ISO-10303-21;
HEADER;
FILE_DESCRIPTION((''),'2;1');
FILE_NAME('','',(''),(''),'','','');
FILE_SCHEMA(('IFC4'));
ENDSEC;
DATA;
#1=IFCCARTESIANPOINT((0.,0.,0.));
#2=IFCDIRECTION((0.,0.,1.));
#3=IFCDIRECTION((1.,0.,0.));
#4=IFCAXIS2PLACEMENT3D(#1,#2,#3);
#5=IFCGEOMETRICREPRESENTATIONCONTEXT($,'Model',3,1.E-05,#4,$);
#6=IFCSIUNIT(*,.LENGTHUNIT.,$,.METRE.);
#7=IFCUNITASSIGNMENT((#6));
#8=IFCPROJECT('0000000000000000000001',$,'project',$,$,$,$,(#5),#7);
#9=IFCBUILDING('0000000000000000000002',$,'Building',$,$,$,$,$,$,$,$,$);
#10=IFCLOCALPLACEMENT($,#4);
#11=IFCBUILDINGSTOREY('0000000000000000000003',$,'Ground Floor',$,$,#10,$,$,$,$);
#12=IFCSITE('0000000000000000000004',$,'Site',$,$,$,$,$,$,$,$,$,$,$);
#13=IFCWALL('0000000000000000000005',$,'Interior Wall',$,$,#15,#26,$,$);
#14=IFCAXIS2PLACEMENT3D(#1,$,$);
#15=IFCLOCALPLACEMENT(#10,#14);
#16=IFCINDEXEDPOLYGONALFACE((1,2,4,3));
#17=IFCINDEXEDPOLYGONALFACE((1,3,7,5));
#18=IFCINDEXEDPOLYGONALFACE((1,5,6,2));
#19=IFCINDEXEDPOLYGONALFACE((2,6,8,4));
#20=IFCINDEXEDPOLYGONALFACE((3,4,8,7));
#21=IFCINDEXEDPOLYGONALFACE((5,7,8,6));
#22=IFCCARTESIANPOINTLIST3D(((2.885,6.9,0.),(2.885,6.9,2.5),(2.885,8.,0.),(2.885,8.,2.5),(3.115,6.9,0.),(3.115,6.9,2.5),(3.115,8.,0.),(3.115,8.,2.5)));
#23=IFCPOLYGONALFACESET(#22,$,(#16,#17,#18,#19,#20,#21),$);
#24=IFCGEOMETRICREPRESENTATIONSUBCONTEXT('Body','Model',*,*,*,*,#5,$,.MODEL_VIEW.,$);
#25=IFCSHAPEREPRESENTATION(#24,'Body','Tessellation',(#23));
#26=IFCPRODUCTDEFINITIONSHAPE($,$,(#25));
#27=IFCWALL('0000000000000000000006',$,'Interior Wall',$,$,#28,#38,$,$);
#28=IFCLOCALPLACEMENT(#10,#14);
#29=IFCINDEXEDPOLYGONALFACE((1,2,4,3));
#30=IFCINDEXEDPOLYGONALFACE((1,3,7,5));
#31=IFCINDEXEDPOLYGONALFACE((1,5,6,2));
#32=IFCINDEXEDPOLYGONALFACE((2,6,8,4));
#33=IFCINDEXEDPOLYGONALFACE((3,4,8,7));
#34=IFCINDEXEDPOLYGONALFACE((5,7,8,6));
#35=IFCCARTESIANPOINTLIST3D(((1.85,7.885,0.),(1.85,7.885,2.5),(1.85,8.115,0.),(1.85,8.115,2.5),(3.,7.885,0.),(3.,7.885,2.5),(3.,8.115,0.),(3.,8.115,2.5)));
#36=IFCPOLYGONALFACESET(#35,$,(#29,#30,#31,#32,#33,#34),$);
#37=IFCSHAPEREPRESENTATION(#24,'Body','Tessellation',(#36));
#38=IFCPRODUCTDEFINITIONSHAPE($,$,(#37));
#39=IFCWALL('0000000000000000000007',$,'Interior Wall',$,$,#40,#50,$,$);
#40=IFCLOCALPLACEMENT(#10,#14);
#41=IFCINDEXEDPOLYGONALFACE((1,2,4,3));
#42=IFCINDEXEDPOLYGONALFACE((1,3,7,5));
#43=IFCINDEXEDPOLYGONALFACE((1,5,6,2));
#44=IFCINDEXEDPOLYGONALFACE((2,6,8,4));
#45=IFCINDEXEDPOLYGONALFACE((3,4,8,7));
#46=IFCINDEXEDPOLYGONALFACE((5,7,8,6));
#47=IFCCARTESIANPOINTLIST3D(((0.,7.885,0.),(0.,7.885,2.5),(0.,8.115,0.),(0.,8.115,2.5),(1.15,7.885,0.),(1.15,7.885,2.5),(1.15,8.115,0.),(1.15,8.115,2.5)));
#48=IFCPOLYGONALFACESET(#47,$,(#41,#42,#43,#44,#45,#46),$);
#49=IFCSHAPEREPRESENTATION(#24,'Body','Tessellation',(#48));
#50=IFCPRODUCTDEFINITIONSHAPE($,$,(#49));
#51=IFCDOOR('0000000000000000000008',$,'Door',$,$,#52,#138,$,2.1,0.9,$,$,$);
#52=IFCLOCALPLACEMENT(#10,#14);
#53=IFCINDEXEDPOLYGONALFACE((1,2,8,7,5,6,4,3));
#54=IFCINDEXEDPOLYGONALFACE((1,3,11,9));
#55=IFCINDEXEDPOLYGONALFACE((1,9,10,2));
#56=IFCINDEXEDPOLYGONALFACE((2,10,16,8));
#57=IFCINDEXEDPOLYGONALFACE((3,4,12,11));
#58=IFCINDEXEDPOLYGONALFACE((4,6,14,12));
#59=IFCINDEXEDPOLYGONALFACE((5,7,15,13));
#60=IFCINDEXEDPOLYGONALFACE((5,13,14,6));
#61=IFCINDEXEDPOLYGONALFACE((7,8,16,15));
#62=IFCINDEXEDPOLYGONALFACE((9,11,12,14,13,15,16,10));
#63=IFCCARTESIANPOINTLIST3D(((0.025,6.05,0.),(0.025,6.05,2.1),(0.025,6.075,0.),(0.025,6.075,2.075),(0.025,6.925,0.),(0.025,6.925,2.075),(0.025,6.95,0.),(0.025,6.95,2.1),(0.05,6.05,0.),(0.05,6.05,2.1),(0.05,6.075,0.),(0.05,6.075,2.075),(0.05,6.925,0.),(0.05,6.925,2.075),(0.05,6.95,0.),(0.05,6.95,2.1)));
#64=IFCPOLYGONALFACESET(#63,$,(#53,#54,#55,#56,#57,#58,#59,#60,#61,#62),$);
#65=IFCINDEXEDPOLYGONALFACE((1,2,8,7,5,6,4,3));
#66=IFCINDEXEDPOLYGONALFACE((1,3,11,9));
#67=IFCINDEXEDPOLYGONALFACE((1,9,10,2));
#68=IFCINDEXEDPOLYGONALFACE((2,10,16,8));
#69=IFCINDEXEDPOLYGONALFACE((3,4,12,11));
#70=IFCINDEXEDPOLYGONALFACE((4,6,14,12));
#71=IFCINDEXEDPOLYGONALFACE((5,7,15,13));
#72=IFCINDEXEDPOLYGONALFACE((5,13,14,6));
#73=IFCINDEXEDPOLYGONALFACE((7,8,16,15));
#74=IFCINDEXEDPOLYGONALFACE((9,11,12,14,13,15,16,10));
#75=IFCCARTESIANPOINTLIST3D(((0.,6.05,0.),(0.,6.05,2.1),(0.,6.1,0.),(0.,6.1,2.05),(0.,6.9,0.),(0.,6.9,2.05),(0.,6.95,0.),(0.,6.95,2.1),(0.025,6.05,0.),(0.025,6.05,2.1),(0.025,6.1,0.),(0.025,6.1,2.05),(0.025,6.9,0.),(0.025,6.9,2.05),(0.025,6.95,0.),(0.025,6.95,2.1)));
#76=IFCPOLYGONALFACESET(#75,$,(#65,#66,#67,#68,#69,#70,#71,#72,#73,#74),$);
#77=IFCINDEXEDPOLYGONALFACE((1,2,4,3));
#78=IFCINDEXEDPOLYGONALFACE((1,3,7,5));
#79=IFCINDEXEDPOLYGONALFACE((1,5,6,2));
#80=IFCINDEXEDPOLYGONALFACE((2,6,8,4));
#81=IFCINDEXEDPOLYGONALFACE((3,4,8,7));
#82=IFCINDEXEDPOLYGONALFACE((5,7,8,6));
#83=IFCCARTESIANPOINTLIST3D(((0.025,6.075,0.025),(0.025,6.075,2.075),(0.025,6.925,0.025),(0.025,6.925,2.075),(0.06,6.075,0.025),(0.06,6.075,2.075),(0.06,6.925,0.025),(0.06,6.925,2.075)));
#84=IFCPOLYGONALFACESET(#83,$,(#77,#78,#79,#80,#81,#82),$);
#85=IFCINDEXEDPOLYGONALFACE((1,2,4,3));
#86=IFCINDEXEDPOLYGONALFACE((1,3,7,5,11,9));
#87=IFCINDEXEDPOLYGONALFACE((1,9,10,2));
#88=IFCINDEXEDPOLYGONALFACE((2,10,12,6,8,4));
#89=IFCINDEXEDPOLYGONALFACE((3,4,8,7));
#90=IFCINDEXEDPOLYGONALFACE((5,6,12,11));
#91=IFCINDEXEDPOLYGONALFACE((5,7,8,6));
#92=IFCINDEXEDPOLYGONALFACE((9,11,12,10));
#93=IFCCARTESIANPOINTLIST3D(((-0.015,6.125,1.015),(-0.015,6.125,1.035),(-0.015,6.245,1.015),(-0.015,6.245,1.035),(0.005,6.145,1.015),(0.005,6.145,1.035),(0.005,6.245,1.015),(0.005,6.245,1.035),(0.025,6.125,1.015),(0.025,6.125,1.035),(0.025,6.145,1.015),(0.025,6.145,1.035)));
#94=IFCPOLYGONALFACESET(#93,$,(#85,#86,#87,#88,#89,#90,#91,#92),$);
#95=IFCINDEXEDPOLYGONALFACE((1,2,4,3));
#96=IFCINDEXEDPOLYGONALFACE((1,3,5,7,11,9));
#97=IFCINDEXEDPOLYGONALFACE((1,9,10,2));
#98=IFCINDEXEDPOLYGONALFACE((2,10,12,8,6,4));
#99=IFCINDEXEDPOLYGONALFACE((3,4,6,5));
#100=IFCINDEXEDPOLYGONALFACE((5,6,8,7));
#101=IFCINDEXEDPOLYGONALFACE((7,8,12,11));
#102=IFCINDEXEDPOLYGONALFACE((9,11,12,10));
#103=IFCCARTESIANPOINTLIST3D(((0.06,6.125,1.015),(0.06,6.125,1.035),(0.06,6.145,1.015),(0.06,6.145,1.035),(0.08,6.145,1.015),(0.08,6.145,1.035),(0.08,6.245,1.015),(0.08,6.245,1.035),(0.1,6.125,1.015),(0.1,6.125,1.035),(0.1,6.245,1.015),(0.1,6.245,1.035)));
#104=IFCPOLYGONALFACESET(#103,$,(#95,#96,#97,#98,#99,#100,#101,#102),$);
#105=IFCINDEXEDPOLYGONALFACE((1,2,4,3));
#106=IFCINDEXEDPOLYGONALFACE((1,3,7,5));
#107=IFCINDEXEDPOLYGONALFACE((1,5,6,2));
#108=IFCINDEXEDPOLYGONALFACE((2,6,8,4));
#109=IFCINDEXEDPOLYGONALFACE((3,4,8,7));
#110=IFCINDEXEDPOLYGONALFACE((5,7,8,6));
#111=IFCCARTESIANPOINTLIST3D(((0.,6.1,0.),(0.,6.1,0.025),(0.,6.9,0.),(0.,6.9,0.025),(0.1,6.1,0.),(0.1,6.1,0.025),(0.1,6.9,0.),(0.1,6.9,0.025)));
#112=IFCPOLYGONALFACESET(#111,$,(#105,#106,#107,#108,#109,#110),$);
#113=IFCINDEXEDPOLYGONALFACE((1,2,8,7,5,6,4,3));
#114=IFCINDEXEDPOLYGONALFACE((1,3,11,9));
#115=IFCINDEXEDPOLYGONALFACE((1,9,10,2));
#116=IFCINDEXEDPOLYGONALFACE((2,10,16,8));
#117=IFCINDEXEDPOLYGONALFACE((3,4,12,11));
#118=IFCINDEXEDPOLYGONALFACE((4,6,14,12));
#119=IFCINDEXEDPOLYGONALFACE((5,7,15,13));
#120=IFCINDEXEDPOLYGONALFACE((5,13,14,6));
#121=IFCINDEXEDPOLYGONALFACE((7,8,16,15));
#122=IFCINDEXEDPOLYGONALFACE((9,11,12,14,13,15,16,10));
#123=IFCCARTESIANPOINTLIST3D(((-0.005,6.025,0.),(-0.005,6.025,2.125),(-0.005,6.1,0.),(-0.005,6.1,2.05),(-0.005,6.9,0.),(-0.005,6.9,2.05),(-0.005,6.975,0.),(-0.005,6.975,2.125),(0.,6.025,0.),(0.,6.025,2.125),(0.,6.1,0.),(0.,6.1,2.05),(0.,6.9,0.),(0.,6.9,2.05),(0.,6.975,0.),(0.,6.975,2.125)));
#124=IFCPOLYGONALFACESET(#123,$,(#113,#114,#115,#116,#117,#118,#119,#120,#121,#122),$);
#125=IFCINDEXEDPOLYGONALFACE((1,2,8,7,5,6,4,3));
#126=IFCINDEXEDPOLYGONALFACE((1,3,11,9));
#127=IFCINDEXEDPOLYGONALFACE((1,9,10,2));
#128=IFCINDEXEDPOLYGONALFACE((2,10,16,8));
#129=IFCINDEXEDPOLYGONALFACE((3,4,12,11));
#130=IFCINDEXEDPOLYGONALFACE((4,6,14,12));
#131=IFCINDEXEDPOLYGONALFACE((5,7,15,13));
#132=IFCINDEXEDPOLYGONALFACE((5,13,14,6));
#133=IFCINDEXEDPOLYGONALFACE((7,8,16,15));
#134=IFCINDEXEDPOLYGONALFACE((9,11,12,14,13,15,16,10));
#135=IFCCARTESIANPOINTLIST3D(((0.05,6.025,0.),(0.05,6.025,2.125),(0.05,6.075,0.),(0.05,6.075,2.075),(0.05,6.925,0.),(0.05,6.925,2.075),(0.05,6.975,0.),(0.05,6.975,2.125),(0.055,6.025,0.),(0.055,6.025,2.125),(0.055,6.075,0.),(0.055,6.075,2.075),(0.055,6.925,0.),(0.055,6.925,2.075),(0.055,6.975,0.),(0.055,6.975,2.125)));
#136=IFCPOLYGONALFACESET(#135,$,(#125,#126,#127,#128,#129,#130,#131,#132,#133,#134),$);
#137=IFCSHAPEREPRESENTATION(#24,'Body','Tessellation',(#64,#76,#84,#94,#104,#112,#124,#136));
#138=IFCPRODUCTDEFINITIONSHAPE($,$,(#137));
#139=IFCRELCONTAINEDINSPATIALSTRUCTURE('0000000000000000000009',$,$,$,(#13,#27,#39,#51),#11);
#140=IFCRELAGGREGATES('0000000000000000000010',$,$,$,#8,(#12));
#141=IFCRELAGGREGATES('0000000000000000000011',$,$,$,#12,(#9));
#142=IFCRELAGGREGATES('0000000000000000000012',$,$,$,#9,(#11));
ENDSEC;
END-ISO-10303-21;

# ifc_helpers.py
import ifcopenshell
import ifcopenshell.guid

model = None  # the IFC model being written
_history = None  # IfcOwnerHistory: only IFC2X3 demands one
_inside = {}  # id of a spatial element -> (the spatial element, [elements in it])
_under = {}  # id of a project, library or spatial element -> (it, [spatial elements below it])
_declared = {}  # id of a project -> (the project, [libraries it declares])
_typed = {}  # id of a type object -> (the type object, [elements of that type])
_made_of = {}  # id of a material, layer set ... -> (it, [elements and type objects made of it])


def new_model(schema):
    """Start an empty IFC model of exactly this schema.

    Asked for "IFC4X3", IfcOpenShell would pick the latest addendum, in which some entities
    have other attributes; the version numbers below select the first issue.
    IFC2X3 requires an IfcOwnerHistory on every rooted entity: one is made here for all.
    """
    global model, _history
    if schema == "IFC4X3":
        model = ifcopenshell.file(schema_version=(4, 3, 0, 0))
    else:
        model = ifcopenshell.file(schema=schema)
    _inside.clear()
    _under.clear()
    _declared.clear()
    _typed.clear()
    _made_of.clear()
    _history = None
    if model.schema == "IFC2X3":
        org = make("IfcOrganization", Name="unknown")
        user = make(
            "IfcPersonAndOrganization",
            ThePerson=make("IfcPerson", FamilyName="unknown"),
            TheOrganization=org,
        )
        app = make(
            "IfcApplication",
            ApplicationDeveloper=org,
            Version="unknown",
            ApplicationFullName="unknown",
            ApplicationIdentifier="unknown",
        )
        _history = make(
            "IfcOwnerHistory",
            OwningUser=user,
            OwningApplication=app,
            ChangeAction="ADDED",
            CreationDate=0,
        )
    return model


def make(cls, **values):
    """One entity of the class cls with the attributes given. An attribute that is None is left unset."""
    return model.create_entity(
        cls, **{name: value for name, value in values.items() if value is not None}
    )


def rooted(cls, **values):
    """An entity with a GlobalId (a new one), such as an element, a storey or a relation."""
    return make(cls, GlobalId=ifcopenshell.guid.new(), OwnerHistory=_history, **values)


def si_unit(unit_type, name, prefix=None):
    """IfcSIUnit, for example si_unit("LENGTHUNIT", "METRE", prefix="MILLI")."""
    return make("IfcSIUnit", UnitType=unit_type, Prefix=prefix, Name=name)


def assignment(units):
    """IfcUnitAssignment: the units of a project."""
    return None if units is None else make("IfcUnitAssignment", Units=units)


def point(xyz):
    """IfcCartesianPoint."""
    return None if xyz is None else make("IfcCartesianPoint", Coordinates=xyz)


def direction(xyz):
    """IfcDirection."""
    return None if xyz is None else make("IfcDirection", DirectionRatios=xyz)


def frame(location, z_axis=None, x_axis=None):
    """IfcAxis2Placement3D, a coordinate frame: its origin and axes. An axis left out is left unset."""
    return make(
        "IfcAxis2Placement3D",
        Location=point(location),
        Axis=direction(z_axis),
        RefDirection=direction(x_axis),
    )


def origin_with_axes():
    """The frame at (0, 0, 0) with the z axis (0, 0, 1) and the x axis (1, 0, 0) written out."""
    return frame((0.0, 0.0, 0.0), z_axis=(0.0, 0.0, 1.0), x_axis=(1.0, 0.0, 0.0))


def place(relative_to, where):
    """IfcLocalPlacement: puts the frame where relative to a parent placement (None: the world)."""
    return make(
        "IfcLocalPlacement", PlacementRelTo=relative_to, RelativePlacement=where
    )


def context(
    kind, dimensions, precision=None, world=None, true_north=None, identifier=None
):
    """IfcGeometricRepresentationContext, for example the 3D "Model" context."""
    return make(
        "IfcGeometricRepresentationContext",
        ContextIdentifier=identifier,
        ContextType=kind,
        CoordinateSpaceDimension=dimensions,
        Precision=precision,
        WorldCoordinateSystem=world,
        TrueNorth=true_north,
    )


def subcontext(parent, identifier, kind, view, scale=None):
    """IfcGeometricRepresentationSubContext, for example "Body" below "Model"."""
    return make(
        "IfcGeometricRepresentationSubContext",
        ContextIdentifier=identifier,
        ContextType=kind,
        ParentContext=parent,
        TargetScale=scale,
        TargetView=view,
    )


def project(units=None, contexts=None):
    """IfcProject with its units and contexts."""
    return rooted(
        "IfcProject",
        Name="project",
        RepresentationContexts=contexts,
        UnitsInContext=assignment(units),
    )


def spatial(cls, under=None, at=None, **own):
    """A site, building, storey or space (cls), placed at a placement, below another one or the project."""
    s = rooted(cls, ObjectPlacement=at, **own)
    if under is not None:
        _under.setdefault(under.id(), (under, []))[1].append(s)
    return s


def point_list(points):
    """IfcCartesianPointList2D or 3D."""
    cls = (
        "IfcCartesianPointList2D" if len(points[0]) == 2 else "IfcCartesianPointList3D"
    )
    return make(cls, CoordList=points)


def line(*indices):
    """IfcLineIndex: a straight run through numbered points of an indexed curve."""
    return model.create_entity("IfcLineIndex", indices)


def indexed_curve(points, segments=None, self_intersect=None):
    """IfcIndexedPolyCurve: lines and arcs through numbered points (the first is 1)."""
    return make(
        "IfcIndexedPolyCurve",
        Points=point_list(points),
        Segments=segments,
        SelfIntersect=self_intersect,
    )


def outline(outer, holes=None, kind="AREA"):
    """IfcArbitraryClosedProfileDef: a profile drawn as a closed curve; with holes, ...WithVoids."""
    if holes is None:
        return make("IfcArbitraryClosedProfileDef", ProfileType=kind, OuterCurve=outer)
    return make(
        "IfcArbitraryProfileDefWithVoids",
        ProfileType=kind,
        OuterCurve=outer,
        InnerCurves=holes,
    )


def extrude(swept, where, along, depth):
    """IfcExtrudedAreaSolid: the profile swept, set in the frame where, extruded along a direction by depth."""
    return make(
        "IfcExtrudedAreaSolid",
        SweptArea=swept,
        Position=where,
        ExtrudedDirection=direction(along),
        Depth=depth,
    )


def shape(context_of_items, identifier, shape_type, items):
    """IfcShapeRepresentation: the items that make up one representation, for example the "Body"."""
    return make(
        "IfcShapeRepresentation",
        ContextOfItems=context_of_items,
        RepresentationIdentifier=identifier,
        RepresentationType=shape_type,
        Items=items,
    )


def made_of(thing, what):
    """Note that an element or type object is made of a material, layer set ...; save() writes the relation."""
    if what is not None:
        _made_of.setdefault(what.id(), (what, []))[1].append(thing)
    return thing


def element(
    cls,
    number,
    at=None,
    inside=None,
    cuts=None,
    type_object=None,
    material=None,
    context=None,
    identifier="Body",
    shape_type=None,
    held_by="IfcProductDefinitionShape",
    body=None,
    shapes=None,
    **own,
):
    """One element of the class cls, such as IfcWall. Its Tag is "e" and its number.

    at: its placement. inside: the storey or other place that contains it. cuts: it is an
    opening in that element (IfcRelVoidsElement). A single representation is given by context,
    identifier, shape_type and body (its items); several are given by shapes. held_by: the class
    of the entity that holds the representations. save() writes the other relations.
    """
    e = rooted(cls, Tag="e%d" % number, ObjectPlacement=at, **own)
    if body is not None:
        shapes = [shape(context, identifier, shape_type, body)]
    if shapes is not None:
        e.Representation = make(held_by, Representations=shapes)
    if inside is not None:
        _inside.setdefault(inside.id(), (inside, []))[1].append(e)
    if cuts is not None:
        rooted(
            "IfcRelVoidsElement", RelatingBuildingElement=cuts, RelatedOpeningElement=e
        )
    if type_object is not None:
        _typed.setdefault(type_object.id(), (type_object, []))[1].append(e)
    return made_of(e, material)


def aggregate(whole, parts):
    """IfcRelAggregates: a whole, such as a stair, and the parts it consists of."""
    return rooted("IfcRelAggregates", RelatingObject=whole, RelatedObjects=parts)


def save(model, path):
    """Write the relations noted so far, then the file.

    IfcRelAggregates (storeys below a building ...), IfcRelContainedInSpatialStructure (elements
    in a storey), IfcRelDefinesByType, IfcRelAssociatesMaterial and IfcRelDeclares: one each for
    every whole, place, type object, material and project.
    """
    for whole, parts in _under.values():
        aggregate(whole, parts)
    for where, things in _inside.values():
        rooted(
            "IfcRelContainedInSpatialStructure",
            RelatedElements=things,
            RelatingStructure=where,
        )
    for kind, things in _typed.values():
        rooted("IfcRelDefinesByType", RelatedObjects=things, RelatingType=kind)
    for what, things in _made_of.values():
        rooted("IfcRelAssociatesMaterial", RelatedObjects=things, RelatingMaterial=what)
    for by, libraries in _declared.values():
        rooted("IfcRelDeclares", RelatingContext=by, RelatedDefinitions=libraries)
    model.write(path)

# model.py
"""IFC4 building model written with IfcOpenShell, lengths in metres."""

from ifc_helpers import new_model, si_unit, frame, origin_with_axes, place, context, subcontext, project, spatial, line, indexed_curve, outline, extrude, element, save


model = new_model("IFC4")

# Units and contexts
model_context = context("Model", 3, precision=1e-05, world=origin_with_axes())
body_context = subcontext(model_context, "Body", "Model", "MODEL_VIEW")
ifc_project = project(units=[si_unit("LENGTHUNIT", "METRE")], contexts=[model_context])

# Site, building, storey
site = spatial("IfcSite", under=ifc_project, Name="Site")
building = spatial("IfcBuilding", under=site, Name="Building")
storey_placement = place(None, origin_with_axes())
storey = spatial("IfcBuildingStorey", under=building, at=storey_placement, Name="Ground Floor")

# Walls
for number, where, z_axis, x_axis, name in (
    (1, (3.0, 6.9, 0.0), (0.0, 0.0, 1.0), (0.0, 1.0, 0.0), "Interior Wall"),
):
    element("IfcWall", number, at=place(storey_placement, frame(where, z_axis=z_axis, x_axis=x_axis)), inside=storey, Name=name, context=body_context, shape_type="SweptSolid", body=[
        extrude(outline(indexed_curve([(0.0, 0.0), (0.0, 0.23), (1.1, 0.23), (1.1, 0.0), (0.0, 0.0)], self_intersect=False)), frame((0.0, -0.115, 0.0), z_axis=(0.0, 0.0, 1.0), x_axis=(1.0, 0.0, 0.0)), (0.0, 0.0, 1.0), 2.5),
    ])
for number, where, z_axis, x_axis, name in (
    (2, (3.0, 8.0, 0.0), (0.0, 0.0, 1.0), (-1.0, 0.0, 0.0), "Interior Wall"),
    (3, (1.15, 8.0, 0.0), (0.0, 0.0, 1.0), (-1.0, 0.0, 0.0), "Interior Wall"),
):
    element("IfcWall", number, at=place(storey_placement, frame(where, z_axis=z_axis, x_axis=x_axis)), inside=storey, Name=name, context=body_context, shape_type="SweptSolid", body=[
        extrude(outline(indexed_curve([(0.0, 0.0), (0.0, 0.23), (1.15, 0.23), (1.15, 0.0), (0.0, 0.0)], self_intersect=False)), frame((0.0, -0.115, 0.0), z_axis=(0.0, 0.0, 1.0), x_axis=(1.0, 0.0, 0.0)), (0.0, 0.0, 1.0), 2.5),
    ])

# Door
door_1_placement = place(storey_placement, frame((0.0, 6.95, 0.0), z_axis=(0.0, 0.0, 1.0), x_axis=(0.0, -1.0, 0.0)))
element("IfcDoor", 4, at=door_1_placement, inside=storey, Name="Door", OverallHeight=2.1, OverallWidth=0.9, context=body_context, shape_type="SweptSolid", body=[
    extrude(outline(indexed_curve([(0.0, 0.0), (0.0, 2.1), (0.9, 2.1), (0.9, 0.0), (0.875, 0.0), (0.875, 2.075), (0.025, 2.075), (0.025, 0.0)], segments=[line(1, 2, 3, 4, 5, 6, 7, 8, 1)])), frame((0.0, 0.025, 0.0), z_axis=(0.0, -1.0, 0.0), x_axis=(1.0, 0.0, 0.0)), (0.0, 0.0, -1.0), 0.025),
    extrude(outline(indexed_curve([(0.0, 0.0), (0.0, 2.1), (0.9, 2.1), (0.9, 0.0), (0.85, 0.0), (0.85, 2.05), (0.05, 2.05), (0.05, 0.0)], segments=[line(1, 2, 3, 4, 5, 6, 7, 8, 1)])), frame((0.0, 0.0, 0.0), z_axis=(0.0, -1.0, 0.0), x_axis=(1.0, 0.0, 0.0)), (0.0, 0.0, -1.0), 0.025),
    extrude(outline(indexed_curve([(0.0, 0.0), (0.85, 0.0), (0.85, 0.035), (0.0, 0.035)], segments=[line(1, 2, 3, 4, 1)])), frame((0.025, 0.025, 0.025), z_axis=(0.0, 0.0, 1.0), x_axis=(1.0, 0.0, 0.0)), (0.0, 0.0, 1.0), 2.05),
    extrude(outline(indexed_curve([(0.0, 0.0), (0.0, -0.04), (-0.12, -0.04), (-0.12, -0.02), (-0.02, -0.02), (-0.02, 0.0)], segments=[line(1, 2, 3, 4, 5, 6, 1)])), frame((0.825, 0.025, 1.015), z_axis=(0.0, 0.0, 1.0), x_axis=(1.0, 0.0, 0.0)), (0.0, 0.0, 1.0), 0.02),
    extrude(outline(indexed_curve([(0.0, 0.0), (0.0, 0.04), (-0.12, 0.04), (-0.12, 0.02), (-0.02, 0.02), (-0.02, 0.0)], segments=[line(1, 2, 3, 4, 5, 6, 1)])), frame((0.825, 0.06, 1.015), z_axis=(0.0, 0.0, 1.0), x_axis=(1.0, 0.0, 0.0)), (0.0, 0.0, 1.0), 0.02),
    extrude(outline(indexed_curve([(0.0, 0.0), (0.8, 0.0), (0.8, 0.1), (0.0, 0.1)], segments=[line(1, 2, 3, 4, 1)])), frame((0.05, 0.0, 0.0), z_axis=(0.0, 0.0, 1.0), x_axis=(1.0, 0.0, 0.0)), (0.0, 0.0, 1.0), 0.025),
    extrude(outline(indexed_curve([(0.0, 0.0), (0.0, 2.125), (0.95, 2.125), (0.95, 0.0), (0.875, 0.0), (0.875, 2.05), (0.075, 2.05), (0.075, 0.0)], segments=[line(1, 2, 3, 4, 5, 6, 7, 8, 1)])), frame((-0.025, -0.005, 0.0), z_axis=(0.0, -1.0, 0.0), x_axis=(1.0, 0.0, 0.0)), (0.0, 0.0, -1.0), 0.005),
    extrude(outline(indexed_curve([(0.0, 0.0), (0.0, 2.125), (0.95, 2.125), (0.95, 0.0), (0.9, 0.0), (0.9, 2.075), (0.05, 2.075), (0.05, 0.0)], segments=[line(1, 2, 3, 4, 5, 6, 7, 8, 1)])), frame((-0.025, 0.05, 0.0), z_axis=(0.0, -1.0, 0.0), x_axis=(1.0, 0.0, 0.0)), (0.0, 0.0, -1.0), 0.005),
])

save(model, "model.ifc")
